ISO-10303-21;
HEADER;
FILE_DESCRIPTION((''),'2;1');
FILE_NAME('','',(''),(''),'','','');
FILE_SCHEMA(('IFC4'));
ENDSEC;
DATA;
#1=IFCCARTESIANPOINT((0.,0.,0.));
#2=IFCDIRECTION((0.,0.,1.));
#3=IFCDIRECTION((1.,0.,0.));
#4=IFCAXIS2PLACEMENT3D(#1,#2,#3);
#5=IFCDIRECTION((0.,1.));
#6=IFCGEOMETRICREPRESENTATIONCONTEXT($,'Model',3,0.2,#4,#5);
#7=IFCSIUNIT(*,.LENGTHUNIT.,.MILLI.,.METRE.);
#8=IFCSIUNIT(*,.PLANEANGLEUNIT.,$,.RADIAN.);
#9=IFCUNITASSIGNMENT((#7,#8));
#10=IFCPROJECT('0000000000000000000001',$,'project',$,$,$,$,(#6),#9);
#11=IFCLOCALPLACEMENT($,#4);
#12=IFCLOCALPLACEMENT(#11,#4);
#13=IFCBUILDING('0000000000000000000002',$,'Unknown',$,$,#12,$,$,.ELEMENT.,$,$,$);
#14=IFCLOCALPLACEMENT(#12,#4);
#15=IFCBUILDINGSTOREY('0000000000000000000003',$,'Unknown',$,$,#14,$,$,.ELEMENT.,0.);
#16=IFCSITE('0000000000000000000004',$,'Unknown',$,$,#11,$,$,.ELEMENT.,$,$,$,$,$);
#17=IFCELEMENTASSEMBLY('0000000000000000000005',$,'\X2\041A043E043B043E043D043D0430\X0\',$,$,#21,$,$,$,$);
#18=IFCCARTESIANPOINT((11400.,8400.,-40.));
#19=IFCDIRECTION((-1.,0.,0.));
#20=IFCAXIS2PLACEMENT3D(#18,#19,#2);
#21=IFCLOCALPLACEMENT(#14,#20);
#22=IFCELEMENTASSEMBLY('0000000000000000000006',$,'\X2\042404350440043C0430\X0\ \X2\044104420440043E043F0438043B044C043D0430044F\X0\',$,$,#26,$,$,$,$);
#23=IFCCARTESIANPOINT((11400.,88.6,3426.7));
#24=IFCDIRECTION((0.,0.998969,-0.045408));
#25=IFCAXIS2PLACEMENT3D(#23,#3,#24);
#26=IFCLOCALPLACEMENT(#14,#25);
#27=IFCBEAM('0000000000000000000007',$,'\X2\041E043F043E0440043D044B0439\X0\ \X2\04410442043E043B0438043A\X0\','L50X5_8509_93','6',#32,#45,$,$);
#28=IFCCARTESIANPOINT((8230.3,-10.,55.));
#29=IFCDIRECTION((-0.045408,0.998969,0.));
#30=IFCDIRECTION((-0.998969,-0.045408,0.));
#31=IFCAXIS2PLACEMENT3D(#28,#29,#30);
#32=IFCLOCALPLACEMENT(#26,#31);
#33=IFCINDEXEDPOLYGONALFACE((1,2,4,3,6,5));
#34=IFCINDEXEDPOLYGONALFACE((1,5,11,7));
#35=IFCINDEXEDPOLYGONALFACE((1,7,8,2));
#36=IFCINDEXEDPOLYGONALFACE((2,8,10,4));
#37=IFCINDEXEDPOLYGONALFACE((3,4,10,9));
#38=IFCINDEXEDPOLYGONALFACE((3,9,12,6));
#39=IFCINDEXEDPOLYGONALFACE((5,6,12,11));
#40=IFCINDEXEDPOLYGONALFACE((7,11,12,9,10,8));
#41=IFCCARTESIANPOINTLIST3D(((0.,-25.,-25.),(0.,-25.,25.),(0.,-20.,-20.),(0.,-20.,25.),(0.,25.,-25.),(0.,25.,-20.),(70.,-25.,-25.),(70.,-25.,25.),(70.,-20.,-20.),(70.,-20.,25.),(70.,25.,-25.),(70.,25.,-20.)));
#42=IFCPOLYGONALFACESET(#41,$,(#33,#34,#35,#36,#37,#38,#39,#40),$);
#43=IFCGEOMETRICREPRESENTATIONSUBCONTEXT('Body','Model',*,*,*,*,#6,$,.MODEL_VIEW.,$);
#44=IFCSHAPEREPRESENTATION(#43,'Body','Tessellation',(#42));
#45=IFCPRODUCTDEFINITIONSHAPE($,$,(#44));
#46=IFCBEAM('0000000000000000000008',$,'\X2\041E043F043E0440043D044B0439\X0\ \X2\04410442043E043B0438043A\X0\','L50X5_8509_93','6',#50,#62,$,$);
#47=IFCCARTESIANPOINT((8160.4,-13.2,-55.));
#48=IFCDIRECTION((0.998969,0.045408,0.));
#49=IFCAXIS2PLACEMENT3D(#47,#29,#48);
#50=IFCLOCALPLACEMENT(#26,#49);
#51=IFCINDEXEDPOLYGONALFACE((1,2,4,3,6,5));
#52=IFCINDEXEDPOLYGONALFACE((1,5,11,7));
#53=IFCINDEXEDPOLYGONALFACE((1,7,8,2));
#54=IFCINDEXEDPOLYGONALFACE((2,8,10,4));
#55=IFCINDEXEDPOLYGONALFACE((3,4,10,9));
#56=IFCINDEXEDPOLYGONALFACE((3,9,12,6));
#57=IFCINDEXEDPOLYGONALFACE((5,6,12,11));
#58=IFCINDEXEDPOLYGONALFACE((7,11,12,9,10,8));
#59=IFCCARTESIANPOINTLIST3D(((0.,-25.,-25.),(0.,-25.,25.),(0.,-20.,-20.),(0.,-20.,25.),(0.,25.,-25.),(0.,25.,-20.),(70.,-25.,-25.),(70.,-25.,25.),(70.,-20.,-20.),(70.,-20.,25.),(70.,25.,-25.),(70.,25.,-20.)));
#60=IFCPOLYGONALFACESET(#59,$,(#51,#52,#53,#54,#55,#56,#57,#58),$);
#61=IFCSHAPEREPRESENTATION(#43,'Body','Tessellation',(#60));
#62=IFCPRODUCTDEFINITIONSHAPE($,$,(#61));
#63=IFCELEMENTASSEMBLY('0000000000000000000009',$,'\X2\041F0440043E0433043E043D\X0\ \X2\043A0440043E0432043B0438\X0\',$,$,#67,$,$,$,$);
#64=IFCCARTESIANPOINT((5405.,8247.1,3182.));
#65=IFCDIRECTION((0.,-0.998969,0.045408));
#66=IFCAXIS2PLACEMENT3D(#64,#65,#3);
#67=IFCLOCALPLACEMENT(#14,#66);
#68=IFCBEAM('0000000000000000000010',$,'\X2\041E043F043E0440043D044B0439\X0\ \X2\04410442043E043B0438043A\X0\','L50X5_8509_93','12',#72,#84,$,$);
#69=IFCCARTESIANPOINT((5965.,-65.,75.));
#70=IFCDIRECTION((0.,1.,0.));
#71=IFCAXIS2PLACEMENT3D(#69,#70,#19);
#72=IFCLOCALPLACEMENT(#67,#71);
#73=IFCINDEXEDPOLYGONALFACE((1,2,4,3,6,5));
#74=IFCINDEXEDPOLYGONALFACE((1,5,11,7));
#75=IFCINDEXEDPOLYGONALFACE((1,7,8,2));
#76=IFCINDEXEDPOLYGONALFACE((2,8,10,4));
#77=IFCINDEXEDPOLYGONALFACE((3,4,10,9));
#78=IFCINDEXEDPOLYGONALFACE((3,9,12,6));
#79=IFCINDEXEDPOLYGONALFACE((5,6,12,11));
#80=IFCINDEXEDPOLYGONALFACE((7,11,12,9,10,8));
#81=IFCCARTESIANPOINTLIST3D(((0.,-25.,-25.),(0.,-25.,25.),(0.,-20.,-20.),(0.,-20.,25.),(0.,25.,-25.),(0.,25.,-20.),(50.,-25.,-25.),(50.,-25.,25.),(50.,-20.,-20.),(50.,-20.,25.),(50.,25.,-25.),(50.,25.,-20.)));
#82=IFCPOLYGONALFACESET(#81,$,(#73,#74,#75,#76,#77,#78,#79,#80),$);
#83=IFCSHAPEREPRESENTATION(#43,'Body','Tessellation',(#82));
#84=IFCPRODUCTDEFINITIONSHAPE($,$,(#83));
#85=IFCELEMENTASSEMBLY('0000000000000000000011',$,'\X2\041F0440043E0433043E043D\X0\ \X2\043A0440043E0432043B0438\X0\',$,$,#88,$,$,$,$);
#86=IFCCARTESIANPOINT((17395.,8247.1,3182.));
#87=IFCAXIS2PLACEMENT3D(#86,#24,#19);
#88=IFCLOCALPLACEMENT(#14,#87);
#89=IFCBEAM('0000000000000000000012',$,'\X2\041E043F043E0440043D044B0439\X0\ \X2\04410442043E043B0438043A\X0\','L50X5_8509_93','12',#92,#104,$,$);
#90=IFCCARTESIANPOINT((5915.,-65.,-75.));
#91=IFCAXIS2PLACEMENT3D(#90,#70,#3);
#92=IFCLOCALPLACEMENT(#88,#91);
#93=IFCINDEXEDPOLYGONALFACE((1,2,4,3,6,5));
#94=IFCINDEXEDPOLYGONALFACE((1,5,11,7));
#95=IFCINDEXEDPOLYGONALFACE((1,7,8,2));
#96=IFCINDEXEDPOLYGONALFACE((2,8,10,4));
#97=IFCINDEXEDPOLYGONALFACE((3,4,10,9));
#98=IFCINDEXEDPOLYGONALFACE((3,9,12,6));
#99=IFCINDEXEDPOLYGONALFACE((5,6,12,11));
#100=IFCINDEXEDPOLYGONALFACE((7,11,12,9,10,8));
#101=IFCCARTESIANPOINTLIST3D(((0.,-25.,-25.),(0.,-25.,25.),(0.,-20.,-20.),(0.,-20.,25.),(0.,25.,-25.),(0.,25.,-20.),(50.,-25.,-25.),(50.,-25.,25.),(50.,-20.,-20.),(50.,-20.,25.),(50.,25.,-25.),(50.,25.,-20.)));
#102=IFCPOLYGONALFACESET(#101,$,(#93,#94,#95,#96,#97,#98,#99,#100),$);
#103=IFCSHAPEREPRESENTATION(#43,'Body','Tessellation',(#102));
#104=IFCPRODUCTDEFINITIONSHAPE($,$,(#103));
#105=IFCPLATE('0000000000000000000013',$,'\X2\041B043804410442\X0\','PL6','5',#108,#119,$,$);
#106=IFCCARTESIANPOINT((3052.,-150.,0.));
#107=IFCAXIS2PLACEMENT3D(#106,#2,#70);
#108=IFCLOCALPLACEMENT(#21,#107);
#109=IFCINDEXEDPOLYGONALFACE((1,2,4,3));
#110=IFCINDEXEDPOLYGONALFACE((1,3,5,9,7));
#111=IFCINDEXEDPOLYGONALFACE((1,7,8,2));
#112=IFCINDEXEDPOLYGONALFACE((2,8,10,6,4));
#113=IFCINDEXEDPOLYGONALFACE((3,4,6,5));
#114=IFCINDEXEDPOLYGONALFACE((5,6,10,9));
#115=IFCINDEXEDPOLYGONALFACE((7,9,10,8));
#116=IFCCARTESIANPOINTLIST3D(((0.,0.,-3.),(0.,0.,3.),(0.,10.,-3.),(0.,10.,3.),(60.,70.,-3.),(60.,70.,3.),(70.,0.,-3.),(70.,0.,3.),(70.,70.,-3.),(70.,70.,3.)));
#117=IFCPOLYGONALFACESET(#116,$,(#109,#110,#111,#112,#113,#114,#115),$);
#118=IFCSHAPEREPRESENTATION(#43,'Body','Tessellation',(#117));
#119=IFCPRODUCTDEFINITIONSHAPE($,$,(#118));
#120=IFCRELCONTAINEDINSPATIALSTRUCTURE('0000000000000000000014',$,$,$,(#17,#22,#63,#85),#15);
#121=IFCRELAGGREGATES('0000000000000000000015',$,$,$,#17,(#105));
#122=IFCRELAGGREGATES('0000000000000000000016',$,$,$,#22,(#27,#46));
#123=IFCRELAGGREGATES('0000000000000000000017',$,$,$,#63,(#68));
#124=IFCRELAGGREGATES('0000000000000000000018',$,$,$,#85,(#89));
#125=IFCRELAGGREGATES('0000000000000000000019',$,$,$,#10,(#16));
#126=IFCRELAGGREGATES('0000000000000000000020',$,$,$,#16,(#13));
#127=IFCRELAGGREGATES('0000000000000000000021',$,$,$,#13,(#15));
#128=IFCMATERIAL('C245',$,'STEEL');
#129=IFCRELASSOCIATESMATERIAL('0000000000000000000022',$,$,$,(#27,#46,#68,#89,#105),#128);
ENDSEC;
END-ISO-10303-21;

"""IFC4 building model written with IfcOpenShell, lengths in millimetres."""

from ifc_helpers import new_model, si_unit, direction, frame, origin_with_axes, place, context, subcontext, project, spatial, line, indexed_curve, outline, extrude, material, element, aggregate, save


model = new_model("IFC4")

# Units and contexts
model_context = context("Model", 3, precision=0.2, world=origin_with_axes(), true_north=direction((0.0, 1.0)))
body_context = subcontext(model_context, "Body", "Model", "MODEL_VIEW")
ifc_project = project(units=[si_unit("LENGTHUNIT", "METRE", prefix="MILLI"), si_unit("PLANEANGLEUNIT", "RADIAN")], contexts=[model_context])

# Site, building, storey
site_placement = place(None, origin_with_axes())
site = spatial("IfcSite", under=ifc_project, at=site_placement, Name="Unknown", CompositionType="ELEMENT")
building_placement = place(site_placement, origin_with_axes())
building = spatial("IfcBuilding", under=site, at=building_placement, Name="Unknown", CompositionType="ELEMENT")
storey_placement = place(building_placement, origin_with_axes())
storey = spatial("IfcBuildingStorey", under=building, at=storey_placement, Name="Unknown", CompositionType="ELEMENT", Elevation=0.0)

# Shared definitions
ifc_material_1 = material(Name="C245", Category="STEEL")

# Element assembly
assembly_1_placement = place(storey_placement, frame((11400.0, 8400.0, -40.0), z_axis=(-1.0, 0.0, 0.0), x_axis=(0.0, 0.0, 1.0)))
assembly_1 = element("IfcElementAssembly", 1, at=assembly_1_placement, inside=storey, Name="Колонна")

# Element assembly, beams
assembly_2_placement = place(storey_placement, frame((11400.0, 88.6, 3426.7), z_axis=(1.0, 0.0, 0.0), x_axis=(0.0, 0.998969, -0.045408)))
assembly_2 = element("IfcElementAssembly", 2, at=assembly_2_placement, inside=storey, Name="Ферма стропильная")
beam_1_placement = place(assembly_2_placement, frame((8230.3, -10.0, 55.0), z_axis=(-0.045408, 0.998969, 0.0), x_axis=(-0.998969, -0.045408, 0.0)))
beam_1 = element("IfcBeam", 3, at=beam_1_placement, material=ifc_material_1, Name="Опорный столик", Description="L50X5_8509_93", ObjectType="6", context=body_context, shape_type="SolidModel", body=[
    extrude(outline(indexed_curve([(-25.0, -25.0), (25.0, -25.0), (25.0, -20.0), (-20.0, -20.0), (-20.0, 25.0), (-25.0, 25.0)], segments=[line(1, 2, 3, 4, 5, 6, 1)])), frame((0.0, 0.0, 0.0), z_axis=(-1.0, 0.0, 0.0), x_axis=(0.0, 0.0, 1.0)), (0.0, 0.0, -1.0), 70.0),
])
beam_2_placement = place(assembly_2_placement, frame((8160.4, -13.2, -55.0), z_axis=(-0.045408, 0.998969, 0.0), x_axis=(0.998969, 0.045408, 0.0)))
beam_2 = element("IfcBeam", 4, at=beam_2_placement, material=ifc_material_1, Name="Опорный столик", Description="L50X5_8509_93", ObjectType="6", context=body_context, shape_type="SolidModel", body=[
    extrude(outline(indexed_curve([(-25.0, -25.0), (25.0, -25.0), (25.0, -20.0), (-20.0, -20.0), (-20.0, 25.0), (-25.0, 25.0)], segments=[line(1, 2, 3, 4, 5, 6, 1)])), frame((0.0, 0.0, 0.0), z_axis=(-1.0, 0.0, 0.0), x_axis=(0.0, 0.0, 1.0)), (0.0, 0.0, -1.0), 70.0),
])

# Element assembly, beam
assembly_3_placement = place(storey_placement, frame((5405.0, 8247.1, 3182.0), z_axis=(0.0, -0.998969, 0.045408), x_axis=(1.0, 0.0, 0.0)))
assembly_3 = element("IfcElementAssembly", 5, at=assembly_3_placement, inside=storey, Name="Прогон кровли")
beam_3_placement = place(assembly_3_placement, frame((5965.0, -65.0, 75.0), z_axis=(0.0, 1.0, 0.0), x_axis=(-1.0, 0.0, 0.0)))
beam_3 = element("IfcBeam", 6, at=beam_3_placement, material=ifc_material_1, Name="Опорный столик", Description="L50X5_8509_93", ObjectType="12", context=body_context, shape_type="SolidModel", body=[
    extrude(outline(indexed_curve([(-25.0, -25.0), (25.0, -25.0), (25.0, -20.0), (-20.0, -20.0), (-20.0, 25.0), (-25.0, 25.0)], segments=[line(1, 2, 3, 4, 5, 6, 1)])), frame((0.0, 0.0, 0.0), z_axis=(-1.0, 0.0, 0.0), x_axis=(0.0, 0.0, 1.0)), (0.0, 0.0, -1.0), 50.0),
])

# Element assembly, beam
assembly_4_placement = place(storey_placement, frame((17395.0, 8247.1, 3182.0), z_axis=(0.0, 0.998969, -0.045408), x_axis=(-1.0, 0.0, 0.0)))
assembly_4 = element("IfcElementAssembly", 7, at=assembly_4_placement, inside=storey, Name="Прогон кровли")
beam_4_placement = place(assembly_4_placement, frame((5915.0, -65.0, -75.0), z_axis=(0.0, 1.0, 0.0), x_axis=(1.0, 0.0, 0.0)))
beam_4 = element("IfcBeam", 8, at=beam_4_placement, material=ifc_material_1, Name="Опорный столик", Description="L50X5_8509_93", ObjectType="12", context=body_context, shape_type="SolidModel", body=[
    extrude(outline(indexed_curve([(-25.0, -25.0), (25.0, -25.0), (25.0, -20.0), (-20.0, -20.0), (-20.0, 25.0), (-25.0, 25.0)], segments=[line(1, 2, 3, 4, 5, 6, 1)])), frame((0.0, 0.0, 0.0), z_axis=(-1.0, 0.0, 0.0), x_axis=(0.0, 0.0, 1.0)), (0.0, 0.0, -1.0), 50.0),
])

# Plate
plate_1_placement = place(assembly_1_placement, frame((3052.0, -150.0, 0.0), z_axis=(0.0, 0.0, 1.0), x_axis=(0.0, 1.0, 0.0)))
plate_1 = element("IfcPlate", 9, at=plate_1_placement, material=ifc_material_1, Name="Лист", Description="PL6", ObjectType="5", context=body_context, shape_type="SolidModel", body=[
    extrude(outline(indexed_curve([(0.0, 0.0), (70.0, 0.0), (70.0, 70.0), (60.0, 70.0), (0.0, 10.0)], segments=[line(1, 2, 3, 4, 5, 1)])), frame((0.0, 0.0, 3.0), z_axis=(0.0, 0.0, 1.0), x_axis=(1.0, 0.0, 0.0)), (0.0, 0.0, -1.0), 6.0),
])

aggregate(assembly_1, [plate_1])
aggregate(assembly_2, [beam_1, beam_2])
aggregate(assembly_3, [beam_3])
aggregate(assembly_4, [beam_4])

save(model, "model.ifc")
